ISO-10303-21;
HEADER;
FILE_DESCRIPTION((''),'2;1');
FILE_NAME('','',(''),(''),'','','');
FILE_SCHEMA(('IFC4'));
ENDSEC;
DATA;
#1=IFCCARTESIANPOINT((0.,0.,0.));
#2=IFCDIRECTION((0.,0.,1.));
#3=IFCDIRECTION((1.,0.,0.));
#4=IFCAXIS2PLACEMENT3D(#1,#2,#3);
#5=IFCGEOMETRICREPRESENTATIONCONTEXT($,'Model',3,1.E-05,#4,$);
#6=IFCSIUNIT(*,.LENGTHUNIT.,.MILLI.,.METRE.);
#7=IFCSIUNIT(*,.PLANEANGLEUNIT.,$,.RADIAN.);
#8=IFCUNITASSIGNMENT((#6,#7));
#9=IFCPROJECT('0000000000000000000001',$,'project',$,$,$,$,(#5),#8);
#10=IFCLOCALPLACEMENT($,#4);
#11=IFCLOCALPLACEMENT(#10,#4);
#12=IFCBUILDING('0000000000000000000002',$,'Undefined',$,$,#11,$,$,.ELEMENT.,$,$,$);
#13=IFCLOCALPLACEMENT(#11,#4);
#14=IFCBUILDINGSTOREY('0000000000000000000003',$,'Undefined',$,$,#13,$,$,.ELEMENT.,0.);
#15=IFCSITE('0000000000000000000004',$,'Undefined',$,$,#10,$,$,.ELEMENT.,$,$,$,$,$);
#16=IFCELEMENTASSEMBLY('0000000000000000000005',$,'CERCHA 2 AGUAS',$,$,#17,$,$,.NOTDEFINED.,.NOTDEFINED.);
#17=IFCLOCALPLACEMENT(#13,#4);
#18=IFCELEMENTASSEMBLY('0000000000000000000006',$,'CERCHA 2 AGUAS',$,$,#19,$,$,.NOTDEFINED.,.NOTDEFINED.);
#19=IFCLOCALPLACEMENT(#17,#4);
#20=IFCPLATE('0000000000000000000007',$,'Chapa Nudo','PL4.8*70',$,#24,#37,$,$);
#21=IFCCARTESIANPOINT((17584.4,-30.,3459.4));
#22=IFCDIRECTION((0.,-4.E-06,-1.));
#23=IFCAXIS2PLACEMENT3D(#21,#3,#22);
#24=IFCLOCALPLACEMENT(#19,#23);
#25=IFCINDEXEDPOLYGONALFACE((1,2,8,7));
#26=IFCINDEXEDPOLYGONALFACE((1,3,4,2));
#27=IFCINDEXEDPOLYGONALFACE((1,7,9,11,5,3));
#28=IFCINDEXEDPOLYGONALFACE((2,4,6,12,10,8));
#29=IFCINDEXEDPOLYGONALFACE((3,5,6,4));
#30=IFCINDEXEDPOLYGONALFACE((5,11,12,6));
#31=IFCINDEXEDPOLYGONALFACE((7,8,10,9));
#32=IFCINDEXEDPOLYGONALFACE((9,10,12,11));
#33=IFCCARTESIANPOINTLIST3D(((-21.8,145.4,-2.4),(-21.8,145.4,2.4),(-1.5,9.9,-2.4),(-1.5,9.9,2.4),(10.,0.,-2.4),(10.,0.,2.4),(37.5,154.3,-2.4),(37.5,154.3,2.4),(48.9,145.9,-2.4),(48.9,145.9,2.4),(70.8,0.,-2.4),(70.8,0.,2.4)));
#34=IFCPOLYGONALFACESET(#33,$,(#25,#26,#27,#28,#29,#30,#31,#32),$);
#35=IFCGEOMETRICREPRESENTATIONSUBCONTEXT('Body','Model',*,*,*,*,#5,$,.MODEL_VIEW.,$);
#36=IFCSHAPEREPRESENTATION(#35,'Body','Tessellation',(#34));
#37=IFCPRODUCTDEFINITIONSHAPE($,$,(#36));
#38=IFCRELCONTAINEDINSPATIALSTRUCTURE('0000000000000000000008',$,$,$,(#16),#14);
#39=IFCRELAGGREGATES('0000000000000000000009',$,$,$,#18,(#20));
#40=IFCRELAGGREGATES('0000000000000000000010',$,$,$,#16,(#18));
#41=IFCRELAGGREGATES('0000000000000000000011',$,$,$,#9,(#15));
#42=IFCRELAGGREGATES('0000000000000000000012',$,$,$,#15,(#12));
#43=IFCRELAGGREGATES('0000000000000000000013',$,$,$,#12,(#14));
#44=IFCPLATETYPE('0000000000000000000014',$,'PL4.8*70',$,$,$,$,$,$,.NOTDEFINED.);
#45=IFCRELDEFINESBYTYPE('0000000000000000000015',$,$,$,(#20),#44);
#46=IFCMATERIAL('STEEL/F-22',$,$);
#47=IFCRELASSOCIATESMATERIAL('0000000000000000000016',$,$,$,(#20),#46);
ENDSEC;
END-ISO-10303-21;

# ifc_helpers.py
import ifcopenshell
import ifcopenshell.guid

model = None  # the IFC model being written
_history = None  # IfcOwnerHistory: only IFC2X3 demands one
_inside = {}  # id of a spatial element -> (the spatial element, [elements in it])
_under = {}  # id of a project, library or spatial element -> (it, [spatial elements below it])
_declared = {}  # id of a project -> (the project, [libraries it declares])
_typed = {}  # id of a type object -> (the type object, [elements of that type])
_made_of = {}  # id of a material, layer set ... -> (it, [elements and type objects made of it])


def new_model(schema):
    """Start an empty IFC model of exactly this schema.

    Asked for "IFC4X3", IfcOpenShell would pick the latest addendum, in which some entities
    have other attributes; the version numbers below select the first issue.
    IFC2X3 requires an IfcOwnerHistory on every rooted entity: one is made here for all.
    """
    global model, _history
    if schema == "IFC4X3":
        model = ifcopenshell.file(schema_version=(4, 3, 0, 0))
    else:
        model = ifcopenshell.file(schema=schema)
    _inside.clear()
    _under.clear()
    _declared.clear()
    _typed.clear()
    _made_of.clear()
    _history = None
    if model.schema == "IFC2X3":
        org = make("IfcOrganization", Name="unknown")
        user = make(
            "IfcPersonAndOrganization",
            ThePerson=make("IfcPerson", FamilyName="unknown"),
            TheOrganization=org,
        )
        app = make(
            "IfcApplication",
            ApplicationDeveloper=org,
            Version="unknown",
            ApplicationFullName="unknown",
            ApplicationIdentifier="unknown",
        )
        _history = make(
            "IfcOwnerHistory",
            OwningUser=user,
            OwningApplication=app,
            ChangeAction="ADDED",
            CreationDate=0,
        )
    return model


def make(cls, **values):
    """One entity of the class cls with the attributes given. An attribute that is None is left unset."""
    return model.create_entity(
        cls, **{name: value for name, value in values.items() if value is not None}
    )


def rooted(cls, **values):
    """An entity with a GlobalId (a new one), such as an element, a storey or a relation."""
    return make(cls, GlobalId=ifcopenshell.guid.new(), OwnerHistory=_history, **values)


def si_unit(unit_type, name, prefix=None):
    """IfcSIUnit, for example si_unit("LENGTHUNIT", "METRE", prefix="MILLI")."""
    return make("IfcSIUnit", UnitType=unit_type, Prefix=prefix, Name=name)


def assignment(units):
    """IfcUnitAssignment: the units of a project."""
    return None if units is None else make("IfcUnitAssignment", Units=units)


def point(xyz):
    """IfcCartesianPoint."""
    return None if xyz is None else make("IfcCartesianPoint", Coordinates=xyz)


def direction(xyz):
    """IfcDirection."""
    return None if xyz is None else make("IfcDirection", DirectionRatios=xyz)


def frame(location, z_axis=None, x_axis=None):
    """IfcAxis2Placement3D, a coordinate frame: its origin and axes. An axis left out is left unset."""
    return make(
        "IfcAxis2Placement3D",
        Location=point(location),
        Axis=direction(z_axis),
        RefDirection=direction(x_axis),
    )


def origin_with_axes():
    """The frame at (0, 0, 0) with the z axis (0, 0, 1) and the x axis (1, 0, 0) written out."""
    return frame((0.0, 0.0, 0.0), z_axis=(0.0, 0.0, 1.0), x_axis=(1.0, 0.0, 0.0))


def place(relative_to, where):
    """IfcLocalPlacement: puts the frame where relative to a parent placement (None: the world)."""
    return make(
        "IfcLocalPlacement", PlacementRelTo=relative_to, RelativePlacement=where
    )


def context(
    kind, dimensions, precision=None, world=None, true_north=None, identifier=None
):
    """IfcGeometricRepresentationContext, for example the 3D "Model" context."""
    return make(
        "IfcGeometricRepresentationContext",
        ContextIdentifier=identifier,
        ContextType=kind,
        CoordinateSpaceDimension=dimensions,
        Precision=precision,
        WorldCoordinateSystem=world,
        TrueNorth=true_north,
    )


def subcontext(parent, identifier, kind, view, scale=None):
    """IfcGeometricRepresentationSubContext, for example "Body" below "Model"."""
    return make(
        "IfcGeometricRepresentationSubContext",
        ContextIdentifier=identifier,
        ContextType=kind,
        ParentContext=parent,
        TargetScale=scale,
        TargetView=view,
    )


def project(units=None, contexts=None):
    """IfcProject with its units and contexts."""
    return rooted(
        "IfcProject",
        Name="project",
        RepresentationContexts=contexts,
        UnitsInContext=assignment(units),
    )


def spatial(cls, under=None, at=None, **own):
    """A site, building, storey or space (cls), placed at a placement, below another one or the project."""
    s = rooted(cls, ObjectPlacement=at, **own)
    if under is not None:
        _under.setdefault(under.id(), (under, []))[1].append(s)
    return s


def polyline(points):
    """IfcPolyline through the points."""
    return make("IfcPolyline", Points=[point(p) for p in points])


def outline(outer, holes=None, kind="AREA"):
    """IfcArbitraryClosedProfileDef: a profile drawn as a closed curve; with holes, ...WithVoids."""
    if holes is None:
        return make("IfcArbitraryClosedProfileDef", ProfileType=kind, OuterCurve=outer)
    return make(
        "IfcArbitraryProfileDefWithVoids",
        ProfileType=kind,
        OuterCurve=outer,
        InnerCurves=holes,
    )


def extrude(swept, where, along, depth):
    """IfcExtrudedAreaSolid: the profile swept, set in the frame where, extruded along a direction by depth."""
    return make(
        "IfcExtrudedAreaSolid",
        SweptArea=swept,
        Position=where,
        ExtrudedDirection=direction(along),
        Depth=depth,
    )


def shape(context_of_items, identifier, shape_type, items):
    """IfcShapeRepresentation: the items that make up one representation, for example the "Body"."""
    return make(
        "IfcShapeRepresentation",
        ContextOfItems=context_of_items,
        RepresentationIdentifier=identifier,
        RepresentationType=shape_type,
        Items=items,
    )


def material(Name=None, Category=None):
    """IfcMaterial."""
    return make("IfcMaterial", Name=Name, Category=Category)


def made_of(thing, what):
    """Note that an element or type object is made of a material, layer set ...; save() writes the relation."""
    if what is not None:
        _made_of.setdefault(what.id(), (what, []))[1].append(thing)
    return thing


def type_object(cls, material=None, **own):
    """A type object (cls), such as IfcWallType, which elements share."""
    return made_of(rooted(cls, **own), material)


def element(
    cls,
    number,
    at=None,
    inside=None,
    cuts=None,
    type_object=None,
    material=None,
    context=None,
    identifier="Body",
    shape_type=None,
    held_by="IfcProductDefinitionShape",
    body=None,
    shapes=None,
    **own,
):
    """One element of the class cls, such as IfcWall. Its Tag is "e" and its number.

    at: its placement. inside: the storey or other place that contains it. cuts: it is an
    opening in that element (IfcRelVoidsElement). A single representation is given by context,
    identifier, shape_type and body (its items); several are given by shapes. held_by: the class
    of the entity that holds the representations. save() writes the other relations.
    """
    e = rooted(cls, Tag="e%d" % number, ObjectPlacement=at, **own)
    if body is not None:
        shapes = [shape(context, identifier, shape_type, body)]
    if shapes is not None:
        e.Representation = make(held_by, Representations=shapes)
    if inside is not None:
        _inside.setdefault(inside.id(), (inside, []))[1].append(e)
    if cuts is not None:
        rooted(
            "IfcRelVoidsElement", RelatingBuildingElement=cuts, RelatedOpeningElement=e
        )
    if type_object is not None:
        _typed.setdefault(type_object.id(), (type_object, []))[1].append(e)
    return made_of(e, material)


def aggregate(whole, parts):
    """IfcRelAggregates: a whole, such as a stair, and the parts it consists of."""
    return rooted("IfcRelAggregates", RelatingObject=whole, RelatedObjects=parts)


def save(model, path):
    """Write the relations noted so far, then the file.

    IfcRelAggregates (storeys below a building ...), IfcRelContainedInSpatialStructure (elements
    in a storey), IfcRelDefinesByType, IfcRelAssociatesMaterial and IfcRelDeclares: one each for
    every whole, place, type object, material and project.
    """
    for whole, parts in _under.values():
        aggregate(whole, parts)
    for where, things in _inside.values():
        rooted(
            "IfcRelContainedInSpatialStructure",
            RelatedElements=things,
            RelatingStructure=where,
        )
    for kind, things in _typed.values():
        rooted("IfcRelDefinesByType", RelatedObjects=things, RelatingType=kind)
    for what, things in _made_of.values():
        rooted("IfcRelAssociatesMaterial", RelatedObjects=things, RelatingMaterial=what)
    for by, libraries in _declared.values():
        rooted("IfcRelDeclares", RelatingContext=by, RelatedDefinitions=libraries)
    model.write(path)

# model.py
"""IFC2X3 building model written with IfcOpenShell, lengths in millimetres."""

from ifc_helpers import new_model, si_unit, frame, origin_with_axes, place, context, subcontext, project, spatial, polyline, outline, extrude, material, type_object, element, aggregate, save


model = new_model("IFC2X3")

# Units and contexts
model_context = context("Model", 3, precision=1e-05, world=origin_with_axes())
body_context = subcontext(model_context, "Body", "Model", "MODEL_VIEW")
ifc_project = project(units=[si_unit("LENGTHUNIT", "METRE", prefix="MILLI"), si_unit("PLANEANGLEUNIT", "RADIAN")], contexts=[model_context])

# Site, building, storey
site_placement = place(None, origin_with_axes())
site = spatial("IfcSite", under=ifc_project, at=site_placement, Name="Undefined", CompositionType="ELEMENT")
building_placement = place(site_placement, origin_with_axes())
building = spatial("IfcBuilding", under=site, at=building_placement, Name="Undefined", CompositionType="ELEMENT")
storey_placement = place(building_placement, origin_with_axes())
storey = spatial("IfcBuildingStorey", under=building, at=storey_placement, Name="Undefined", CompositionType="ELEMENT", Elevation=0.0)

# Element assemblies
assembly_1_placement = place(storey_placement, origin_with_axes())
assembly_1 = element("IfcElementAssembly", 1, at=assembly_1_placement, inside=storey, Name="CERCHA 2 AGUAS", AssemblyPlace="NOTDEFINED", PredefinedType="NOTDEFINED")
assembly_2_placement = place(assembly_1_placement, origin_with_axes())
assembly_2 = element("IfcElementAssembly", 2, at=assembly_2_placement, Name="CERCHA 2 AGUAS", AssemblyPlace="NOTDEFINED", PredefinedType="NOTDEFINED")
ifc_material_1 = material(Name="STEEL/F-22")

# Plate
plate_type_1 = type_object("IfcPlateType", Name="PL4.8*70", PredefinedType="NOTDEFINED")
plate_1_placement = place(assembly_2_placement, frame((17584.4, -30.0, 3459.4), z_axis=(1.0, 0.0, 0.0), x_axis=(0.0, -0.000004, -1.0)))
plate_1 = element("IfcPlate", 3, at=plate_1_placement, type_object=plate_type_1, material=ifc_material_1, Name="Chapa Nudo", Description="PL4.8*70", context=body_context, shape_type="SweptSolid", body=[
    extrude(outline(polyline([(-1.5, 9.9), (10.0, 0.0), (70.8, 0.0), (70.8, 0.0), (48.9, 145.9), (37.5, 154.3), (-21.8, 145.4), (-1.5, 9.9)])), frame((0.0, 0.0, -2.4), z_axis=(0.0, 0.0, 1.0), x_axis=(1.0, 0.0, 0.0)), (0.0, 0.0, 1.0), 4.8),
])

aggregate(assembly_2, [plate_1])
aggregate(assembly_1, [assembly_2])

save(model, "model.ifc")
